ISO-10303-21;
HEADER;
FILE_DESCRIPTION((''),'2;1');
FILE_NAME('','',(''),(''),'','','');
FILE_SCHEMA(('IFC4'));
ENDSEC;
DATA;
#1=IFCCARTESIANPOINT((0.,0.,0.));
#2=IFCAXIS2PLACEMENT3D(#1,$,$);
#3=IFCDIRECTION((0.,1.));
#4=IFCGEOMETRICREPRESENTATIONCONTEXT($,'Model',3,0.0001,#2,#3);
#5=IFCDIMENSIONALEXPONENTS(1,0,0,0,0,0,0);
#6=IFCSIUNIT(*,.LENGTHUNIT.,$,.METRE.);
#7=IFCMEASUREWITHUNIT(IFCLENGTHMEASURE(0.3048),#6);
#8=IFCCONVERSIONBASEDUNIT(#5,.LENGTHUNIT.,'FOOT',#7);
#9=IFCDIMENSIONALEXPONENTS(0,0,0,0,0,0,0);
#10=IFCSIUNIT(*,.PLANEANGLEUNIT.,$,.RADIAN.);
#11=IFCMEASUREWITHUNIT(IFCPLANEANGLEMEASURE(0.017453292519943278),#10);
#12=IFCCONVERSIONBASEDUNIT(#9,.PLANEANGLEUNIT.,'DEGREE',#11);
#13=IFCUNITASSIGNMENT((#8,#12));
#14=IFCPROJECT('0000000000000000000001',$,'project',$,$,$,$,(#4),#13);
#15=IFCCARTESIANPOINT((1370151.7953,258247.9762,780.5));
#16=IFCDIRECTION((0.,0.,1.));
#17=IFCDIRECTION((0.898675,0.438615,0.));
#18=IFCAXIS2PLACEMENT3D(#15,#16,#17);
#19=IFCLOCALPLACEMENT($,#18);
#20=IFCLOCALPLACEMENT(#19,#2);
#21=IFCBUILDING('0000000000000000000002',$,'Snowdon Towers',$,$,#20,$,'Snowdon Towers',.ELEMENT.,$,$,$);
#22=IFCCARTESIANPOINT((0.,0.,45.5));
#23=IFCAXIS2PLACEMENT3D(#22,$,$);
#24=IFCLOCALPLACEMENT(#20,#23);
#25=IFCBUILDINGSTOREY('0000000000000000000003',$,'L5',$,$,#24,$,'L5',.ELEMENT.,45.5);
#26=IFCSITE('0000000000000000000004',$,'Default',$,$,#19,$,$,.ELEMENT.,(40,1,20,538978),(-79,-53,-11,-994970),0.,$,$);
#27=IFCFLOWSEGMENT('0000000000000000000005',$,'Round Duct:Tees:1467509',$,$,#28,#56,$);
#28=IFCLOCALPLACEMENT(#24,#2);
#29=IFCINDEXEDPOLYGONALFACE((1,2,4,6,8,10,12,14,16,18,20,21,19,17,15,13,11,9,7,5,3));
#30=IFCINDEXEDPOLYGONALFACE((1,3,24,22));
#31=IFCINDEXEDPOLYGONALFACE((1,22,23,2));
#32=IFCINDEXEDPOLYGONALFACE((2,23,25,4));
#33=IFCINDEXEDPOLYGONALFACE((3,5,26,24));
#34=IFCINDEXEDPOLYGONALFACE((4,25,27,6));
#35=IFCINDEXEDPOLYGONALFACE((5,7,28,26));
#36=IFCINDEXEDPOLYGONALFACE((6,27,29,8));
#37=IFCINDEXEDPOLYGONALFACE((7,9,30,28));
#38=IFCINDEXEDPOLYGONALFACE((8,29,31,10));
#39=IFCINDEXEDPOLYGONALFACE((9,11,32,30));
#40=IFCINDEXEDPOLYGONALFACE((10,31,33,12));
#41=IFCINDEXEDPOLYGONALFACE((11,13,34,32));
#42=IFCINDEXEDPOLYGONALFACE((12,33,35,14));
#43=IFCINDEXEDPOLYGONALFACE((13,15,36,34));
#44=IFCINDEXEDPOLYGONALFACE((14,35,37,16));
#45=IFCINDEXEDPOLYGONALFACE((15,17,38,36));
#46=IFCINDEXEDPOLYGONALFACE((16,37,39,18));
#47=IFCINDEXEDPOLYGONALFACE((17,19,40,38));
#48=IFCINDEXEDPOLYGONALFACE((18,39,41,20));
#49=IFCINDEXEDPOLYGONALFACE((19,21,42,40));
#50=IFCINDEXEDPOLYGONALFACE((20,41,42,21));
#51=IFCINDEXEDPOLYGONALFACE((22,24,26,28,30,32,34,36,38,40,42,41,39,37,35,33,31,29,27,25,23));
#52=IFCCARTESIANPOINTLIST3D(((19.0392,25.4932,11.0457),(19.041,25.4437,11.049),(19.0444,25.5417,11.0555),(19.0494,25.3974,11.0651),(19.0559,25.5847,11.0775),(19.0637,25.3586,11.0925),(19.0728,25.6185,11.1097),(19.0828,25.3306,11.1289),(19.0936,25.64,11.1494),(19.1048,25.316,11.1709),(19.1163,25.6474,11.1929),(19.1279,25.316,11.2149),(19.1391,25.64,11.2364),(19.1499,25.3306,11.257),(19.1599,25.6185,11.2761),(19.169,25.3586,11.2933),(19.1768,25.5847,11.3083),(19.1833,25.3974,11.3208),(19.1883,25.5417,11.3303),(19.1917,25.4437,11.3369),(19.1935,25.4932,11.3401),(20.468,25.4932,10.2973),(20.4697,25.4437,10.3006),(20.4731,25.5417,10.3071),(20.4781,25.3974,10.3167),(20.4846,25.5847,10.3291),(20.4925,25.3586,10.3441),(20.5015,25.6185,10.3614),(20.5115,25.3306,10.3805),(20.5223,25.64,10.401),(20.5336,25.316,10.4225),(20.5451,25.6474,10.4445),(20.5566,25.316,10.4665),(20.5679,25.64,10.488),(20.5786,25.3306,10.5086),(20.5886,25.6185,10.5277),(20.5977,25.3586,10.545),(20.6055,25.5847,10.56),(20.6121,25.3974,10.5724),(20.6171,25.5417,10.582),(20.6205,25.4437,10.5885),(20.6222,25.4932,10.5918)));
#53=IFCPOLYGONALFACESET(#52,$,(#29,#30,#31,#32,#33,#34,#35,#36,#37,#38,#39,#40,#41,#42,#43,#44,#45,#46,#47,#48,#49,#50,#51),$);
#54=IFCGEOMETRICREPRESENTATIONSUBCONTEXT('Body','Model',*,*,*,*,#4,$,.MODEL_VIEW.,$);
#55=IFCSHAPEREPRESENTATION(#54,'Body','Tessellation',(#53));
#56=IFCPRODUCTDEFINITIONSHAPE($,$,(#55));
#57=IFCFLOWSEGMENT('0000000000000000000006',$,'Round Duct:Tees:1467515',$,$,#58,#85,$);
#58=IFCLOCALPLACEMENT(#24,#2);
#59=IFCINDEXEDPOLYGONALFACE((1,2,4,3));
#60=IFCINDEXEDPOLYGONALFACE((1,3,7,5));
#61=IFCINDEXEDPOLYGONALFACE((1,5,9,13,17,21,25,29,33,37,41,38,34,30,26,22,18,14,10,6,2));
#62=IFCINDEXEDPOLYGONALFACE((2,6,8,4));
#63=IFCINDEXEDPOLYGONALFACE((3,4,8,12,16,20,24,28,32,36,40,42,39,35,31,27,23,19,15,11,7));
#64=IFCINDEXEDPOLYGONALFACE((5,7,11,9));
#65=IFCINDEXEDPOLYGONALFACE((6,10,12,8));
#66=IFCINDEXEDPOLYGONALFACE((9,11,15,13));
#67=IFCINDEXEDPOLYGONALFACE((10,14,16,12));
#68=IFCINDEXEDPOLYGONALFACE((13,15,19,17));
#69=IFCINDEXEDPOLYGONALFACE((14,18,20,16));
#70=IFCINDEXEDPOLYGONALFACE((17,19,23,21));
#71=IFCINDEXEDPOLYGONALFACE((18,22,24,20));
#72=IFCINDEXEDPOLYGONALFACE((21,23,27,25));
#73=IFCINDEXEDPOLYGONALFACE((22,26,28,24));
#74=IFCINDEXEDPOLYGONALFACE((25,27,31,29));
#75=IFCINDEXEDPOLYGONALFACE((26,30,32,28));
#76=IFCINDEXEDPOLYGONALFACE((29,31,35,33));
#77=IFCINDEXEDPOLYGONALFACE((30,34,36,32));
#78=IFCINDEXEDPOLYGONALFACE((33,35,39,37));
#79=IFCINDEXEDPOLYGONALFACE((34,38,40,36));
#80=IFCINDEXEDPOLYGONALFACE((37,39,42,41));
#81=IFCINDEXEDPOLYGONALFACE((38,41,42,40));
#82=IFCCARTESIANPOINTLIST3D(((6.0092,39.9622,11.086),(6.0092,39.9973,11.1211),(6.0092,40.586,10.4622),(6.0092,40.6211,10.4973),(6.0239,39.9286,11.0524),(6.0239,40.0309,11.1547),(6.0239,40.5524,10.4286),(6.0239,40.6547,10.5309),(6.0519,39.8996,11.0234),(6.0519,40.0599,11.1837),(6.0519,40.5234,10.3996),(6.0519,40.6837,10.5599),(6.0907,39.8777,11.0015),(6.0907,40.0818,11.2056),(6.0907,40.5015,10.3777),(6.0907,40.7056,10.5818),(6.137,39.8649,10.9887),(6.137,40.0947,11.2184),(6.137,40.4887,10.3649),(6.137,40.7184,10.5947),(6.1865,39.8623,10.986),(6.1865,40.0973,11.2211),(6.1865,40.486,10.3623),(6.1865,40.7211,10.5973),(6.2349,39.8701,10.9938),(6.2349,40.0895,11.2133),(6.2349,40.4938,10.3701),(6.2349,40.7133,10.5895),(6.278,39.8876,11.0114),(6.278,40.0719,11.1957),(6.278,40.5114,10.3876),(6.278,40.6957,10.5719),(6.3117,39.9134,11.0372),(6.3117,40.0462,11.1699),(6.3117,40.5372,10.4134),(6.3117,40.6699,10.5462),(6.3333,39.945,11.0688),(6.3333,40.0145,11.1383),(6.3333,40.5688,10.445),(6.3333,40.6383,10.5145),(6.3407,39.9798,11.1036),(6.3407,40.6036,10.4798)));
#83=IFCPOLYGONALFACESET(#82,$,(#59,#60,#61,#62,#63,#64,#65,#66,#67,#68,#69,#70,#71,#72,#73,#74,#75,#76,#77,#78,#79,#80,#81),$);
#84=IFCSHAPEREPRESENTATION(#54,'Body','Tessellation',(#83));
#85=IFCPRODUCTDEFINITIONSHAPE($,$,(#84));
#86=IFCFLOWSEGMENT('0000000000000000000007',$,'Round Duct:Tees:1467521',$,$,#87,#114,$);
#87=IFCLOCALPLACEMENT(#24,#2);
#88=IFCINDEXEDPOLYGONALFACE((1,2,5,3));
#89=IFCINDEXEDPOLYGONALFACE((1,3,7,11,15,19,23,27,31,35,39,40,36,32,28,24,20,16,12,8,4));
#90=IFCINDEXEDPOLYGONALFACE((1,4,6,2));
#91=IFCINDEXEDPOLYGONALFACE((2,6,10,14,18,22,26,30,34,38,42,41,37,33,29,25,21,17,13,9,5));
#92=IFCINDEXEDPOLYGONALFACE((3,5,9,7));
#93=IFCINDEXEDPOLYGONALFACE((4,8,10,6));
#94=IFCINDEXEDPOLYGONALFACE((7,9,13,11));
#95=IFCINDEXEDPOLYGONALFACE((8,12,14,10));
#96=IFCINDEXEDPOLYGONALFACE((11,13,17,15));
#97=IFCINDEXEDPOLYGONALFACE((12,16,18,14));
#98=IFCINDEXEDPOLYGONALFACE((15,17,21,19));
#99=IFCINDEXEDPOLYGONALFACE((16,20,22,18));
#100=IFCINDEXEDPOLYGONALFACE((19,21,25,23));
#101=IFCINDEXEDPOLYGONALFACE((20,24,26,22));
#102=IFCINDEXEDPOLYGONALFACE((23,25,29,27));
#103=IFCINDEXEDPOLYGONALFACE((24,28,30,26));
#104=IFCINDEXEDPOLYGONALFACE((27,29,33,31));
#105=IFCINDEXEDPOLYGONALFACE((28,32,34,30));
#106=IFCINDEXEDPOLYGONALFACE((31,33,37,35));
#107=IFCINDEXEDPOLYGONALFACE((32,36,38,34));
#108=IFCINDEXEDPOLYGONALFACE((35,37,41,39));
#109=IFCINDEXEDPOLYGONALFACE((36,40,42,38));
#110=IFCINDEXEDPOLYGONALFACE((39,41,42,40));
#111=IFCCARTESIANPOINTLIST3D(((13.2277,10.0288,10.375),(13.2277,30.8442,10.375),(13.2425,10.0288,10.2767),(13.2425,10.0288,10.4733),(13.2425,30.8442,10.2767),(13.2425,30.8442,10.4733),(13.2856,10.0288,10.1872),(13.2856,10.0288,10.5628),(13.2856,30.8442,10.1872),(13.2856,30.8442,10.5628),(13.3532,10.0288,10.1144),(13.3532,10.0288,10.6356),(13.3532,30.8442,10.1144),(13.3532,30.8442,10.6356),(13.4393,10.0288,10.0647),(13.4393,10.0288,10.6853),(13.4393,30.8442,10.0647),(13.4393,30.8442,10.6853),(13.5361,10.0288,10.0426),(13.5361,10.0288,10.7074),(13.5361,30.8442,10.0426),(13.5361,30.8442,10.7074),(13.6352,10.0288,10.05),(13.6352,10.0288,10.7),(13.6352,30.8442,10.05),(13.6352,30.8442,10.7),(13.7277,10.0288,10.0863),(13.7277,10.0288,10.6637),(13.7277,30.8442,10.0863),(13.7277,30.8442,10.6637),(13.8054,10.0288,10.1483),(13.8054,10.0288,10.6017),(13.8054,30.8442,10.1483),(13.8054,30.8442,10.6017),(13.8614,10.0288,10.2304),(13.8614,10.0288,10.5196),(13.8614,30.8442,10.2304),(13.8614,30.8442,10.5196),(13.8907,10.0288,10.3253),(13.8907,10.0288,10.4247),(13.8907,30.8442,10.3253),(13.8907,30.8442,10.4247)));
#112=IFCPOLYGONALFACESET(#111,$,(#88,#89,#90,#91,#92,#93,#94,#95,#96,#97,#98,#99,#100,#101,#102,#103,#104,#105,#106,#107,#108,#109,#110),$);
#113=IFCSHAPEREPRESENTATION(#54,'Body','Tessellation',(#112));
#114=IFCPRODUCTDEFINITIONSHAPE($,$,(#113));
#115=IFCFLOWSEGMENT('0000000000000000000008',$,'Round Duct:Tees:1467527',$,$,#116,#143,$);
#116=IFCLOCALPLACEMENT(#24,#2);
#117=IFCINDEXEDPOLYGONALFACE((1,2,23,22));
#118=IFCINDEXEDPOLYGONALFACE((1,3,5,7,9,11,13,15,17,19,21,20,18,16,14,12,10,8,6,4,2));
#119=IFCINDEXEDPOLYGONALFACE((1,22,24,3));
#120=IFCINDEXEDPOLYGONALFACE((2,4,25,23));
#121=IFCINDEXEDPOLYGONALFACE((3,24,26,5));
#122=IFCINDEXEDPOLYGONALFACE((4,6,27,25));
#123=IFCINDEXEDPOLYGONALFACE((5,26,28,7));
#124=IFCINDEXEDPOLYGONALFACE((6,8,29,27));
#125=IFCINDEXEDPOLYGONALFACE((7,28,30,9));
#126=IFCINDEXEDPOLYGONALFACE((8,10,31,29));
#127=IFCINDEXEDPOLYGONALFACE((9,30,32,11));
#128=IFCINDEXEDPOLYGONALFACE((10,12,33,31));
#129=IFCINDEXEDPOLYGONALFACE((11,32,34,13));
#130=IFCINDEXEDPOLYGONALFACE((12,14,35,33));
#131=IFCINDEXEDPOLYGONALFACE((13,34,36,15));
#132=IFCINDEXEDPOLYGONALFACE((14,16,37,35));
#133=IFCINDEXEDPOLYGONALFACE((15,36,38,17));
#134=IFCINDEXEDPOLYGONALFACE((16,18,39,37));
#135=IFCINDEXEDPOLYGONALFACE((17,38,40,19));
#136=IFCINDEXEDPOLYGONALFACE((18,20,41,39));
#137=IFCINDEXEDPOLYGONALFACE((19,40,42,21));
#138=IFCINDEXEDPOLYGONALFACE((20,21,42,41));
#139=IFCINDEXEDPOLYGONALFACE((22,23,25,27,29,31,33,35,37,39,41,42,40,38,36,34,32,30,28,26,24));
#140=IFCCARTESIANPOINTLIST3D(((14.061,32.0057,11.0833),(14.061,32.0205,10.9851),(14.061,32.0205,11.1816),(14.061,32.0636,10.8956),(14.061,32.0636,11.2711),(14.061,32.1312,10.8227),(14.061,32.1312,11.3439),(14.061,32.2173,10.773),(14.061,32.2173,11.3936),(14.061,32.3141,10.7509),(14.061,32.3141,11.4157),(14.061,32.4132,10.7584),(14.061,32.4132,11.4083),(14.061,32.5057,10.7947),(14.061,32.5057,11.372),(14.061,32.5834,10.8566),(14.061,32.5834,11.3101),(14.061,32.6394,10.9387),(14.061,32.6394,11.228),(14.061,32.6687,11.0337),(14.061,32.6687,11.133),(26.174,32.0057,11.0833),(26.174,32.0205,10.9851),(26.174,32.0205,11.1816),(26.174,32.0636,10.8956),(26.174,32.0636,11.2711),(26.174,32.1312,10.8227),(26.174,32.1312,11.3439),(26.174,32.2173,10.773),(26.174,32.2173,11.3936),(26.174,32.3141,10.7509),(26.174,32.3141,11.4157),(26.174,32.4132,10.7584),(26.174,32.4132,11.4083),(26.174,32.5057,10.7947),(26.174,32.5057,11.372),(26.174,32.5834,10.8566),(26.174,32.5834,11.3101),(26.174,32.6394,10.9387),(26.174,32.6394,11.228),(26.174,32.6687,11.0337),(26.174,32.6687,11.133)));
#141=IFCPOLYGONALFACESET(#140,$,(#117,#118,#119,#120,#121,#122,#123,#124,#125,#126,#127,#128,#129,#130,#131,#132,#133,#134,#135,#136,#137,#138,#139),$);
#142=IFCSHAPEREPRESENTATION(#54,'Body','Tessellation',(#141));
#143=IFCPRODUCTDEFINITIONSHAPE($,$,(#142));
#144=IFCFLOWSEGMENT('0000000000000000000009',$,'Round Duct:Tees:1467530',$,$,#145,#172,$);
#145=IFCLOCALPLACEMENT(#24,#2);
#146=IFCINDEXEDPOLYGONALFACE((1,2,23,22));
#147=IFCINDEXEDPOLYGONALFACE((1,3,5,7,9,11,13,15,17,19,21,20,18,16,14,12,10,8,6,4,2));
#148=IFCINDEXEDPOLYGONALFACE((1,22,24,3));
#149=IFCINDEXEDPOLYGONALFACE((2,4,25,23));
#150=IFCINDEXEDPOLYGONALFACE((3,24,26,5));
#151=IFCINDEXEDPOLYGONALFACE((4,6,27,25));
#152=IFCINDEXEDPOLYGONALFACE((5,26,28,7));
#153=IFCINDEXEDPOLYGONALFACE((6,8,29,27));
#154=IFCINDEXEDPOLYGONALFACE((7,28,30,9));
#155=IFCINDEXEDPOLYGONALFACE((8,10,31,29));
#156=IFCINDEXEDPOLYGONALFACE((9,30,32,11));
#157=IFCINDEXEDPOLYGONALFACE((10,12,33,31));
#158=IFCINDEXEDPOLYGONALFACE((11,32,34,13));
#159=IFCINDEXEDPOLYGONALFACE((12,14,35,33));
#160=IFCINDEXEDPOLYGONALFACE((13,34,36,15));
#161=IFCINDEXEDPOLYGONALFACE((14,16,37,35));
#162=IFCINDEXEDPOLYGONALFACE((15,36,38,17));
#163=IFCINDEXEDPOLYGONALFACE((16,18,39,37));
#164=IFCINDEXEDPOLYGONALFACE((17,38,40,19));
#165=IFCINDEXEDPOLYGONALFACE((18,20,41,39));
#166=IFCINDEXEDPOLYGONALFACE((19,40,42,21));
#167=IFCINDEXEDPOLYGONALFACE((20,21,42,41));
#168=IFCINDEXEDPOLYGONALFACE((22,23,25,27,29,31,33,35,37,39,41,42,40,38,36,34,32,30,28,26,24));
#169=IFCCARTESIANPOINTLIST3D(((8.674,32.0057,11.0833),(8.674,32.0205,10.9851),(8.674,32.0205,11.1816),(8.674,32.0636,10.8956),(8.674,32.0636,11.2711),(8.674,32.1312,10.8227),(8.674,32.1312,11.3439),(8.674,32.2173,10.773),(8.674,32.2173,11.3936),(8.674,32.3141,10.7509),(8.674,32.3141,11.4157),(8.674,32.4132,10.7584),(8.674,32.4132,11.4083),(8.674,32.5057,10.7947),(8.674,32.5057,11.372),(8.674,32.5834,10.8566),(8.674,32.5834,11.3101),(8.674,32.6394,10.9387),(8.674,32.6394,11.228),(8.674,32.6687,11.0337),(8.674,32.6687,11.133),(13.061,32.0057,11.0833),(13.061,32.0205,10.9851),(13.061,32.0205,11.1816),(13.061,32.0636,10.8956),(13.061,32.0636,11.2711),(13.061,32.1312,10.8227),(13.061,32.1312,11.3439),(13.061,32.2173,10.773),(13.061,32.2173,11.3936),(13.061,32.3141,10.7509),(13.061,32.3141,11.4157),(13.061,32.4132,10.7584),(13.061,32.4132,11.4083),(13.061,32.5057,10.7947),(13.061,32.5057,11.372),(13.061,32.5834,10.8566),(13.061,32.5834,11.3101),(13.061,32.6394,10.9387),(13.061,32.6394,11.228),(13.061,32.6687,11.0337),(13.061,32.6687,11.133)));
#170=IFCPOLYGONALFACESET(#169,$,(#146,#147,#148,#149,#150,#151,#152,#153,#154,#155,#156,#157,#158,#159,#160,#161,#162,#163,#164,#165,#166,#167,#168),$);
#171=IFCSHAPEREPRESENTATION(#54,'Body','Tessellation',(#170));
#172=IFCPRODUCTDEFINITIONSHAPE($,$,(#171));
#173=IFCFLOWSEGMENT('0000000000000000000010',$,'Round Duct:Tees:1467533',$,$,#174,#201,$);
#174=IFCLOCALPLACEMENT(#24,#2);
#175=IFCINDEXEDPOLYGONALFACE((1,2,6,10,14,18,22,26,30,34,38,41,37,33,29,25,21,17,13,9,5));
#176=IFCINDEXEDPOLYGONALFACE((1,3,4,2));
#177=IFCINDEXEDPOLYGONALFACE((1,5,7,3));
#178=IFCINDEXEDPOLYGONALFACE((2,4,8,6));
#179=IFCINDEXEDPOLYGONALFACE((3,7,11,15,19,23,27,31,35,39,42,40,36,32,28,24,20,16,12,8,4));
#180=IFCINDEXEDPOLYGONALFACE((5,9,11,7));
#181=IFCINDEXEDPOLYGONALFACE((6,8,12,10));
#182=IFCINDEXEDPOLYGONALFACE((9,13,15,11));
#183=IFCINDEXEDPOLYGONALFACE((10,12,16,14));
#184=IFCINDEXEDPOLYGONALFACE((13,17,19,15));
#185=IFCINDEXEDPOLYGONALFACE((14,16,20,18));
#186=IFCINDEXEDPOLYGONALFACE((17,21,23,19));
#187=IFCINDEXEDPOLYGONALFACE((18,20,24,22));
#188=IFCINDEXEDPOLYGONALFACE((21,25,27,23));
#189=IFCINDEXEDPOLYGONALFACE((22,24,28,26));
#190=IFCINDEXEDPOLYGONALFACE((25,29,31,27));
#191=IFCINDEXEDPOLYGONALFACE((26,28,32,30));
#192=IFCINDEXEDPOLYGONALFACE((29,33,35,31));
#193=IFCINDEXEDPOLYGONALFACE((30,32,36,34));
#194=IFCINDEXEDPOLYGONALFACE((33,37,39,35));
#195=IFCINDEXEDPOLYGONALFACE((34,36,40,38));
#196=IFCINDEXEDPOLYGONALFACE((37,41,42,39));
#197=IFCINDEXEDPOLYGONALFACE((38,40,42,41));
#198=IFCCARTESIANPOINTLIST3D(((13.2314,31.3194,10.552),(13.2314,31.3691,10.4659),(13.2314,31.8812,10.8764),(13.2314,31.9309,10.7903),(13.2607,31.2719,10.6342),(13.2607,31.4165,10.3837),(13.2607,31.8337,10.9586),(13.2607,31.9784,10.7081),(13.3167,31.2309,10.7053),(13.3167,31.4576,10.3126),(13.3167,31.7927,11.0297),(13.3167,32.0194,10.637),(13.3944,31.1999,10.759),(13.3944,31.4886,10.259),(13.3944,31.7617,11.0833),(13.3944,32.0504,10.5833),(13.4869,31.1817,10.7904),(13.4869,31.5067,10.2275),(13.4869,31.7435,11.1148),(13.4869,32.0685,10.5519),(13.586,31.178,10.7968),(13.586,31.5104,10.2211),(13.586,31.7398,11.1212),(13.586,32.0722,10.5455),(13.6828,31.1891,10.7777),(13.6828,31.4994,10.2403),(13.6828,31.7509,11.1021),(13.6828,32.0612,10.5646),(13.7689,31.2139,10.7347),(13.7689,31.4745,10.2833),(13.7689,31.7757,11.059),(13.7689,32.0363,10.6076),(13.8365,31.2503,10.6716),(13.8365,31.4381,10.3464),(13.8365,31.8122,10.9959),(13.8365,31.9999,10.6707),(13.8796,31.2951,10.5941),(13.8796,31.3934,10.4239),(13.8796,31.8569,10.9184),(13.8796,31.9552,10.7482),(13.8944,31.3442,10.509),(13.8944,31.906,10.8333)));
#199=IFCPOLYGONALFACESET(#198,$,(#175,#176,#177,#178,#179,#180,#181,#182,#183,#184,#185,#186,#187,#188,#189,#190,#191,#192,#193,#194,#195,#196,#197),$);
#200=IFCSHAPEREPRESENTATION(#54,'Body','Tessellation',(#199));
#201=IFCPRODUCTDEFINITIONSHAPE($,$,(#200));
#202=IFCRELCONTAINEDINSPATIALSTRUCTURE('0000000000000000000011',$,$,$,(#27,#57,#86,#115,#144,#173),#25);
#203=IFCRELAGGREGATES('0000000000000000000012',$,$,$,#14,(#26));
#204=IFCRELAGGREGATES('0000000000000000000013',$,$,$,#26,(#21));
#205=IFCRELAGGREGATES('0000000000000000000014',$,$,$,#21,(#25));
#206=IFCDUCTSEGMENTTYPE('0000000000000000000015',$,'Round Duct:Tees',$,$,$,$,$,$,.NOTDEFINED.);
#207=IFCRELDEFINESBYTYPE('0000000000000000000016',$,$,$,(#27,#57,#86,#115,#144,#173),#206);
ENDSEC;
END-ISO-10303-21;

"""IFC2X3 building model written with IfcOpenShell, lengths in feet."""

from ifc_helpers import new_model, entity, si_unit, converted_unit, direction, frame, frame_2d, origin, origin_2d_with_axis, place, context, subcontext, project, spatial, circle, extrude, type_object, element, save


model = new_model("IFC2X3")

# Units and contexts
model_context = context("Model", 3, precision=0.0001, world=origin(), true_north=direction((0.0, 1.0)))
body_context = subcontext(model_context, "Body", "Model", "MODEL_VIEW")
ifc_project = project(units=[converted_unit("LENGTHUNIT", "FOOT", entity("IfcLengthMeasure", 0.3048), si_unit("LENGTHUNIT", "METRE"), dimensions=[1, 0, 0, 0, 0, 0, 0]), converted_unit("PLANEANGLEUNIT", "DEGREE", entity("IfcPlaneAngleMeasure", 0.017453292519943278), si_unit("PLANEANGLEUNIT", "RADIAN"), dimensions=[0, 0, 0, 0, 0, 0, 0])], contexts=[model_context])

# Site, building, storey
site_placement = place(None, frame((1370151.7953, 258247.9762, 780.5), z_axis=(0.0, 0.0, 1.0), x_axis=(0.898675, 0.438615, 0.0)))
site = spatial("IfcSite", under=ifc_project, at=site_placement, Name="Default", CompositionType="ELEMENT", RefLatitude=(40, 1, 20, 538978), RefLongitude=(-79, -53, -11, -994970), RefElevation=0.0)
building_placement = place(site_placement, origin())
building = spatial("IfcBuilding", under=site, at=building_placement, Name="Snowdon Towers", LongName="Snowdon Towers", CompositionType="ELEMENT")
storey_placement = place(building_placement, frame((0.0, 0.0, 45.5)))
storey = spatial("IfcBuildingStorey", under=building, at=storey_placement, Name="L5", LongName="L5", CompositionType="ELEMENT", Elevation=45.5)

# Flow segments
duct_segment_type = type_object("IfcDuctSegmentType", Name="Round Duct:Tees", PredefinedType="NOTDEFINED")
flow_segment_1_placement = place(storey_placement, origin())
element("IfcFlowSegment", 1, at=flow_segment_1_placement, inside=storey, type_object=duct_segment_type, Name="Round Duct:Tees:1467509", context=body_context, shape_type="SweptSolid", body=[
    extrude(circle(Radius=0.1667, at=frame_2d((0.0, 0.0), x_axis=(1.0, 0.0))), frame((19.1163, 25.4808, 11.1929), z_axis=(0.885832, 0.0, -0.464007), x_axis=(0.0, 1.0, 0.0)), (0.0, 0.0, 1.0), 1.6129),
])
flow_segment_2_placement = place(storey_placement, origin())
element("IfcFlowSegment", 2, at=flow_segment_2_placement, inside=storey, type_object=duct_segment_type, Name="Round Duct:Tees:1467515", context=body_context, shape_type="SweptSolid", body=[
    extrude(circle(Radius=0.1667, at=origin_2d_with_axis()), frame((6.174, 39.9798, 11.1036), z_axis=(0.0, 0.707107, -0.707107), x_axis=(1.0, 0.0, 0.0)), (0.0, 0.0, 1.0), 0.8821),
])
flow_segment_3_placement = place(storey_placement, origin())
element("IfcFlowSegment", 3, at=flow_segment_3_placement, inside=storey, type_object=duct_segment_type, Name="Round Duct:Tees:1467521", context=body_context, shape_type="SweptSolid", body=[
    extrude(circle(Radius=0.3333, at=frame_2d((0.0, 0.0), x_axis=(1.0, 0.0))), frame((13.561, 10.0288, 10.375), z_axis=(0.0, 1.0, 0.0), x_axis=(-1.0, 0.0, 0.0)), (0.0, 0.0, 1.0), 20.8154),
])
flow_segment_4_placement = place(storey_placement, origin())
element("IfcFlowSegment", 4, at=flow_segment_4_placement, inside=storey, type_object=duct_segment_type, Name="Round Duct:Tees:1467527", context=body_context, shape_type="SweptSolid", body=[
    extrude(circle(Radius=0.3333, at=origin_2d_with_axis()), frame((14.061, 32.339, 11.0833), z_axis=(1.0, 0.0, 0.0), x_axis=(0.0, -1.0, 0.0)), (0.0, 0.0, 1.0), 12.113),
])
flow_segment_5_placement = place(storey_placement, origin())
element("IfcFlowSegment", 5, at=flow_segment_5_placement, inside=storey, type_object=duct_segment_type, Name="Round Duct:Tees:1467530", context=body_context, shape_type="SweptSolid", body=[
    extrude(circle(Radius=0.3333, at=origin_2d_with_axis()), frame((8.674, 32.339, 11.0833), z_axis=(1.0, 0.0, 0.0), x_axis=(0.0, -1.0, 0.0)), (0.0, 0.0, 1.0), 4.387),
])
flow_segment_6_placement = place(storey_placement, origin())
element("IfcFlowSegment", 6, at=flow_segment_6_placement, inside=storey, type_object=duct_segment_type, Name="Round Duct:Tees:1467533", context=body_context, shape_type="SweptSolid", body=[
    extrude(circle(Radius=0.3333, at=frame_2d((0.0, 0.0), x_axis=(1.0, 0.0))), frame((13.561, 31.3442, 10.509), z_axis=(0.0, 0.866025, 0.5), x_axis=(1.0, 0.0, 0.0)), (0.0, 0.0, 1.0), 0.6487),
])

save(model, "model.ifc")
